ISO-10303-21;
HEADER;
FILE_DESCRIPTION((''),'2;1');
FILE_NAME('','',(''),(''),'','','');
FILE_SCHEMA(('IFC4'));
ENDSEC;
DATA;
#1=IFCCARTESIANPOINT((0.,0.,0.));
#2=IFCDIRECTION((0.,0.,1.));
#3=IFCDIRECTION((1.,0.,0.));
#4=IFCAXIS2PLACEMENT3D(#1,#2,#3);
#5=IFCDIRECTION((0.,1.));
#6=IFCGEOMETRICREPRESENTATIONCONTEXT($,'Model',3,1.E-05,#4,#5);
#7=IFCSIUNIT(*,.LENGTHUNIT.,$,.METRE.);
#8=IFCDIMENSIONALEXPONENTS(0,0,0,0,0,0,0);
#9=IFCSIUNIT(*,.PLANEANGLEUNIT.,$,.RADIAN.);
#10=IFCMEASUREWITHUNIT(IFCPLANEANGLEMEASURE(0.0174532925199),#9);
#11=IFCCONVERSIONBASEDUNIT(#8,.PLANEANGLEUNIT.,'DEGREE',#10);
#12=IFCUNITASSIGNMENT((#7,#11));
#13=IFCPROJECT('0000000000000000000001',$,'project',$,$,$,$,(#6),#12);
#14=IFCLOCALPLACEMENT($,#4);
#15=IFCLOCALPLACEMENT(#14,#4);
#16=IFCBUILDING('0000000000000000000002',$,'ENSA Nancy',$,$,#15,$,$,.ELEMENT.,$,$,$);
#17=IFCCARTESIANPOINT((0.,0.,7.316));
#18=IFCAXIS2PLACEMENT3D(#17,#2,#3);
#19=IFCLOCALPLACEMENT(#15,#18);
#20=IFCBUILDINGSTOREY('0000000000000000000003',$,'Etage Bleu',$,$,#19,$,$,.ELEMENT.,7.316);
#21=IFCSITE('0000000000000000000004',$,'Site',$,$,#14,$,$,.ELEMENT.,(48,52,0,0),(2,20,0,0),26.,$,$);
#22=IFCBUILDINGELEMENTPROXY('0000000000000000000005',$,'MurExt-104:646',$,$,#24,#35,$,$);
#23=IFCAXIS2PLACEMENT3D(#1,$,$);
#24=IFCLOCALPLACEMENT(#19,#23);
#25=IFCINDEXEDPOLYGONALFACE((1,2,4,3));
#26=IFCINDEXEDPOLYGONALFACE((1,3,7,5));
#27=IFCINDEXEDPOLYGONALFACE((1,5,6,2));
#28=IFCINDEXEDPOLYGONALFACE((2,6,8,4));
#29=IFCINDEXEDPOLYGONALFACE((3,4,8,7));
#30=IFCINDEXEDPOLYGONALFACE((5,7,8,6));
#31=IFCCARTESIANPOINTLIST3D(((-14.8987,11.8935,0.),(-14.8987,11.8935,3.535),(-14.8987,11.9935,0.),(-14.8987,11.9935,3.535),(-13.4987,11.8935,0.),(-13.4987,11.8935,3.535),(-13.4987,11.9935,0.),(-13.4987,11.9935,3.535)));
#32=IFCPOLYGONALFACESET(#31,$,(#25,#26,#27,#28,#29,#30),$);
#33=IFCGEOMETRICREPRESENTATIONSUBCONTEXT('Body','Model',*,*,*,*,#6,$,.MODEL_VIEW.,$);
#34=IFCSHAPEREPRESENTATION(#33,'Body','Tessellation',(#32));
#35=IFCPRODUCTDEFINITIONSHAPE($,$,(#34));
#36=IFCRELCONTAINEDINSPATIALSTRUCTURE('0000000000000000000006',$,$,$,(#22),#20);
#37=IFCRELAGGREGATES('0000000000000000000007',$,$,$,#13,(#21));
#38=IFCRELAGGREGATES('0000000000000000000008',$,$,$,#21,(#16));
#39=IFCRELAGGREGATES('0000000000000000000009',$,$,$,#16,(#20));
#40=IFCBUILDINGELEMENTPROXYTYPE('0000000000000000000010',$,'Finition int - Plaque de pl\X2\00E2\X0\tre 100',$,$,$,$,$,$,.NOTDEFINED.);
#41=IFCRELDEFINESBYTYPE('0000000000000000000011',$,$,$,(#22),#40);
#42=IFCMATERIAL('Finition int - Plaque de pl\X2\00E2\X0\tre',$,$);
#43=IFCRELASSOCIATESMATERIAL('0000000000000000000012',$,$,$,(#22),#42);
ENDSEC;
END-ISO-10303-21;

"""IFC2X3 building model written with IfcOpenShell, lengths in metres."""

from ifc_helpers import new_model, entity, si_unit, converted_unit, direction, frame, origin_with_axes, place, context, subcontext, project, spatial, polyline, outline, extrude, material, type_object, element, save


model = new_model("IFC2X3")

# Units and contexts
model_context = context("Model", 3, precision=1e-05, world=origin_with_axes(), true_north=direction((0.0, 1.0)))
body_context = subcontext(model_context, "Body", "Model", "MODEL_VIEW")
ifc_project = project(units=[si_unit("LENGTHUNIT", "METRE"), converted_unit("PLANEANGLEUNIT", "DEGREE", entity("IfcPlaneAngleMeasure", 0.0174532925199), si_unit("PLANEANGLEUNIT", "RADIAN"), dimensions=[0, 0, 0, 0, 0, 0, 0])], contexts=[model_context])

# Site, building, storey
site_placement = place(None, origin_with_axes())
site = spatial("IfcSite", under=ifc_project, at=site_placement, Name="Site", CompositionType="ELEMENT", RefLatitude=(48, 52, 0, 0), RefLongitude=(2, 20, 0, 0), RefElevation=26.0)
building_placement = place(site_placement, origin_with_axes())
building = spatial("IfcBuilding", under=site, at=building_placement, Name="ENSA Nancy", CompositionType="ELEMENT")
storey_placement = place(building_placement, frame((0.0, 0.0, 7.316), z_axis=(0.0, 0.0, 1.0), x_axis=(1.0, 0.0, 0.0)))
storey = spatial("IfcBuildingStorey", under=building, at=storey_placement, Name="Etage Bleu", CompositionType="ELEMENT", Elevation=7.316)

# Shared definitions
ifc_material_1 = material(Name="Finition int - Plaque de plâtre")

# Building element proxy
building_element_proxy_type_1 = type_object("IfcBuildingElementProxyType", Name="Finition int - Plaque de plâtre 100", PredefinedType="NOTDEFINED")
proxy_1_placement = place(storey_placement, frame((-14.8987, 11.8935, 0.0), z_axis=(0.0, 0.0, 1.0), x_axis=(1.0, 0.0, 0.0)))
element("IfcBuildingElementProxy", 1, at=proxy_1_placement, inside=storey, type_object=building_element_proxy_type_1, material=ifc_material_1, Name="MurExt-104:646", context=body_context, shape_type="SweptSolid", body=[
    extrude(outline(polyline([(0.0, 0.0), (1.4, 0.0), (1.4, 0.1), (0.0, 0.1), (0.0, 0.0)])), origin_with_axes(), (0.0, 0.0, 1.0), 3.535),
])

save(model, "model.ifc")
